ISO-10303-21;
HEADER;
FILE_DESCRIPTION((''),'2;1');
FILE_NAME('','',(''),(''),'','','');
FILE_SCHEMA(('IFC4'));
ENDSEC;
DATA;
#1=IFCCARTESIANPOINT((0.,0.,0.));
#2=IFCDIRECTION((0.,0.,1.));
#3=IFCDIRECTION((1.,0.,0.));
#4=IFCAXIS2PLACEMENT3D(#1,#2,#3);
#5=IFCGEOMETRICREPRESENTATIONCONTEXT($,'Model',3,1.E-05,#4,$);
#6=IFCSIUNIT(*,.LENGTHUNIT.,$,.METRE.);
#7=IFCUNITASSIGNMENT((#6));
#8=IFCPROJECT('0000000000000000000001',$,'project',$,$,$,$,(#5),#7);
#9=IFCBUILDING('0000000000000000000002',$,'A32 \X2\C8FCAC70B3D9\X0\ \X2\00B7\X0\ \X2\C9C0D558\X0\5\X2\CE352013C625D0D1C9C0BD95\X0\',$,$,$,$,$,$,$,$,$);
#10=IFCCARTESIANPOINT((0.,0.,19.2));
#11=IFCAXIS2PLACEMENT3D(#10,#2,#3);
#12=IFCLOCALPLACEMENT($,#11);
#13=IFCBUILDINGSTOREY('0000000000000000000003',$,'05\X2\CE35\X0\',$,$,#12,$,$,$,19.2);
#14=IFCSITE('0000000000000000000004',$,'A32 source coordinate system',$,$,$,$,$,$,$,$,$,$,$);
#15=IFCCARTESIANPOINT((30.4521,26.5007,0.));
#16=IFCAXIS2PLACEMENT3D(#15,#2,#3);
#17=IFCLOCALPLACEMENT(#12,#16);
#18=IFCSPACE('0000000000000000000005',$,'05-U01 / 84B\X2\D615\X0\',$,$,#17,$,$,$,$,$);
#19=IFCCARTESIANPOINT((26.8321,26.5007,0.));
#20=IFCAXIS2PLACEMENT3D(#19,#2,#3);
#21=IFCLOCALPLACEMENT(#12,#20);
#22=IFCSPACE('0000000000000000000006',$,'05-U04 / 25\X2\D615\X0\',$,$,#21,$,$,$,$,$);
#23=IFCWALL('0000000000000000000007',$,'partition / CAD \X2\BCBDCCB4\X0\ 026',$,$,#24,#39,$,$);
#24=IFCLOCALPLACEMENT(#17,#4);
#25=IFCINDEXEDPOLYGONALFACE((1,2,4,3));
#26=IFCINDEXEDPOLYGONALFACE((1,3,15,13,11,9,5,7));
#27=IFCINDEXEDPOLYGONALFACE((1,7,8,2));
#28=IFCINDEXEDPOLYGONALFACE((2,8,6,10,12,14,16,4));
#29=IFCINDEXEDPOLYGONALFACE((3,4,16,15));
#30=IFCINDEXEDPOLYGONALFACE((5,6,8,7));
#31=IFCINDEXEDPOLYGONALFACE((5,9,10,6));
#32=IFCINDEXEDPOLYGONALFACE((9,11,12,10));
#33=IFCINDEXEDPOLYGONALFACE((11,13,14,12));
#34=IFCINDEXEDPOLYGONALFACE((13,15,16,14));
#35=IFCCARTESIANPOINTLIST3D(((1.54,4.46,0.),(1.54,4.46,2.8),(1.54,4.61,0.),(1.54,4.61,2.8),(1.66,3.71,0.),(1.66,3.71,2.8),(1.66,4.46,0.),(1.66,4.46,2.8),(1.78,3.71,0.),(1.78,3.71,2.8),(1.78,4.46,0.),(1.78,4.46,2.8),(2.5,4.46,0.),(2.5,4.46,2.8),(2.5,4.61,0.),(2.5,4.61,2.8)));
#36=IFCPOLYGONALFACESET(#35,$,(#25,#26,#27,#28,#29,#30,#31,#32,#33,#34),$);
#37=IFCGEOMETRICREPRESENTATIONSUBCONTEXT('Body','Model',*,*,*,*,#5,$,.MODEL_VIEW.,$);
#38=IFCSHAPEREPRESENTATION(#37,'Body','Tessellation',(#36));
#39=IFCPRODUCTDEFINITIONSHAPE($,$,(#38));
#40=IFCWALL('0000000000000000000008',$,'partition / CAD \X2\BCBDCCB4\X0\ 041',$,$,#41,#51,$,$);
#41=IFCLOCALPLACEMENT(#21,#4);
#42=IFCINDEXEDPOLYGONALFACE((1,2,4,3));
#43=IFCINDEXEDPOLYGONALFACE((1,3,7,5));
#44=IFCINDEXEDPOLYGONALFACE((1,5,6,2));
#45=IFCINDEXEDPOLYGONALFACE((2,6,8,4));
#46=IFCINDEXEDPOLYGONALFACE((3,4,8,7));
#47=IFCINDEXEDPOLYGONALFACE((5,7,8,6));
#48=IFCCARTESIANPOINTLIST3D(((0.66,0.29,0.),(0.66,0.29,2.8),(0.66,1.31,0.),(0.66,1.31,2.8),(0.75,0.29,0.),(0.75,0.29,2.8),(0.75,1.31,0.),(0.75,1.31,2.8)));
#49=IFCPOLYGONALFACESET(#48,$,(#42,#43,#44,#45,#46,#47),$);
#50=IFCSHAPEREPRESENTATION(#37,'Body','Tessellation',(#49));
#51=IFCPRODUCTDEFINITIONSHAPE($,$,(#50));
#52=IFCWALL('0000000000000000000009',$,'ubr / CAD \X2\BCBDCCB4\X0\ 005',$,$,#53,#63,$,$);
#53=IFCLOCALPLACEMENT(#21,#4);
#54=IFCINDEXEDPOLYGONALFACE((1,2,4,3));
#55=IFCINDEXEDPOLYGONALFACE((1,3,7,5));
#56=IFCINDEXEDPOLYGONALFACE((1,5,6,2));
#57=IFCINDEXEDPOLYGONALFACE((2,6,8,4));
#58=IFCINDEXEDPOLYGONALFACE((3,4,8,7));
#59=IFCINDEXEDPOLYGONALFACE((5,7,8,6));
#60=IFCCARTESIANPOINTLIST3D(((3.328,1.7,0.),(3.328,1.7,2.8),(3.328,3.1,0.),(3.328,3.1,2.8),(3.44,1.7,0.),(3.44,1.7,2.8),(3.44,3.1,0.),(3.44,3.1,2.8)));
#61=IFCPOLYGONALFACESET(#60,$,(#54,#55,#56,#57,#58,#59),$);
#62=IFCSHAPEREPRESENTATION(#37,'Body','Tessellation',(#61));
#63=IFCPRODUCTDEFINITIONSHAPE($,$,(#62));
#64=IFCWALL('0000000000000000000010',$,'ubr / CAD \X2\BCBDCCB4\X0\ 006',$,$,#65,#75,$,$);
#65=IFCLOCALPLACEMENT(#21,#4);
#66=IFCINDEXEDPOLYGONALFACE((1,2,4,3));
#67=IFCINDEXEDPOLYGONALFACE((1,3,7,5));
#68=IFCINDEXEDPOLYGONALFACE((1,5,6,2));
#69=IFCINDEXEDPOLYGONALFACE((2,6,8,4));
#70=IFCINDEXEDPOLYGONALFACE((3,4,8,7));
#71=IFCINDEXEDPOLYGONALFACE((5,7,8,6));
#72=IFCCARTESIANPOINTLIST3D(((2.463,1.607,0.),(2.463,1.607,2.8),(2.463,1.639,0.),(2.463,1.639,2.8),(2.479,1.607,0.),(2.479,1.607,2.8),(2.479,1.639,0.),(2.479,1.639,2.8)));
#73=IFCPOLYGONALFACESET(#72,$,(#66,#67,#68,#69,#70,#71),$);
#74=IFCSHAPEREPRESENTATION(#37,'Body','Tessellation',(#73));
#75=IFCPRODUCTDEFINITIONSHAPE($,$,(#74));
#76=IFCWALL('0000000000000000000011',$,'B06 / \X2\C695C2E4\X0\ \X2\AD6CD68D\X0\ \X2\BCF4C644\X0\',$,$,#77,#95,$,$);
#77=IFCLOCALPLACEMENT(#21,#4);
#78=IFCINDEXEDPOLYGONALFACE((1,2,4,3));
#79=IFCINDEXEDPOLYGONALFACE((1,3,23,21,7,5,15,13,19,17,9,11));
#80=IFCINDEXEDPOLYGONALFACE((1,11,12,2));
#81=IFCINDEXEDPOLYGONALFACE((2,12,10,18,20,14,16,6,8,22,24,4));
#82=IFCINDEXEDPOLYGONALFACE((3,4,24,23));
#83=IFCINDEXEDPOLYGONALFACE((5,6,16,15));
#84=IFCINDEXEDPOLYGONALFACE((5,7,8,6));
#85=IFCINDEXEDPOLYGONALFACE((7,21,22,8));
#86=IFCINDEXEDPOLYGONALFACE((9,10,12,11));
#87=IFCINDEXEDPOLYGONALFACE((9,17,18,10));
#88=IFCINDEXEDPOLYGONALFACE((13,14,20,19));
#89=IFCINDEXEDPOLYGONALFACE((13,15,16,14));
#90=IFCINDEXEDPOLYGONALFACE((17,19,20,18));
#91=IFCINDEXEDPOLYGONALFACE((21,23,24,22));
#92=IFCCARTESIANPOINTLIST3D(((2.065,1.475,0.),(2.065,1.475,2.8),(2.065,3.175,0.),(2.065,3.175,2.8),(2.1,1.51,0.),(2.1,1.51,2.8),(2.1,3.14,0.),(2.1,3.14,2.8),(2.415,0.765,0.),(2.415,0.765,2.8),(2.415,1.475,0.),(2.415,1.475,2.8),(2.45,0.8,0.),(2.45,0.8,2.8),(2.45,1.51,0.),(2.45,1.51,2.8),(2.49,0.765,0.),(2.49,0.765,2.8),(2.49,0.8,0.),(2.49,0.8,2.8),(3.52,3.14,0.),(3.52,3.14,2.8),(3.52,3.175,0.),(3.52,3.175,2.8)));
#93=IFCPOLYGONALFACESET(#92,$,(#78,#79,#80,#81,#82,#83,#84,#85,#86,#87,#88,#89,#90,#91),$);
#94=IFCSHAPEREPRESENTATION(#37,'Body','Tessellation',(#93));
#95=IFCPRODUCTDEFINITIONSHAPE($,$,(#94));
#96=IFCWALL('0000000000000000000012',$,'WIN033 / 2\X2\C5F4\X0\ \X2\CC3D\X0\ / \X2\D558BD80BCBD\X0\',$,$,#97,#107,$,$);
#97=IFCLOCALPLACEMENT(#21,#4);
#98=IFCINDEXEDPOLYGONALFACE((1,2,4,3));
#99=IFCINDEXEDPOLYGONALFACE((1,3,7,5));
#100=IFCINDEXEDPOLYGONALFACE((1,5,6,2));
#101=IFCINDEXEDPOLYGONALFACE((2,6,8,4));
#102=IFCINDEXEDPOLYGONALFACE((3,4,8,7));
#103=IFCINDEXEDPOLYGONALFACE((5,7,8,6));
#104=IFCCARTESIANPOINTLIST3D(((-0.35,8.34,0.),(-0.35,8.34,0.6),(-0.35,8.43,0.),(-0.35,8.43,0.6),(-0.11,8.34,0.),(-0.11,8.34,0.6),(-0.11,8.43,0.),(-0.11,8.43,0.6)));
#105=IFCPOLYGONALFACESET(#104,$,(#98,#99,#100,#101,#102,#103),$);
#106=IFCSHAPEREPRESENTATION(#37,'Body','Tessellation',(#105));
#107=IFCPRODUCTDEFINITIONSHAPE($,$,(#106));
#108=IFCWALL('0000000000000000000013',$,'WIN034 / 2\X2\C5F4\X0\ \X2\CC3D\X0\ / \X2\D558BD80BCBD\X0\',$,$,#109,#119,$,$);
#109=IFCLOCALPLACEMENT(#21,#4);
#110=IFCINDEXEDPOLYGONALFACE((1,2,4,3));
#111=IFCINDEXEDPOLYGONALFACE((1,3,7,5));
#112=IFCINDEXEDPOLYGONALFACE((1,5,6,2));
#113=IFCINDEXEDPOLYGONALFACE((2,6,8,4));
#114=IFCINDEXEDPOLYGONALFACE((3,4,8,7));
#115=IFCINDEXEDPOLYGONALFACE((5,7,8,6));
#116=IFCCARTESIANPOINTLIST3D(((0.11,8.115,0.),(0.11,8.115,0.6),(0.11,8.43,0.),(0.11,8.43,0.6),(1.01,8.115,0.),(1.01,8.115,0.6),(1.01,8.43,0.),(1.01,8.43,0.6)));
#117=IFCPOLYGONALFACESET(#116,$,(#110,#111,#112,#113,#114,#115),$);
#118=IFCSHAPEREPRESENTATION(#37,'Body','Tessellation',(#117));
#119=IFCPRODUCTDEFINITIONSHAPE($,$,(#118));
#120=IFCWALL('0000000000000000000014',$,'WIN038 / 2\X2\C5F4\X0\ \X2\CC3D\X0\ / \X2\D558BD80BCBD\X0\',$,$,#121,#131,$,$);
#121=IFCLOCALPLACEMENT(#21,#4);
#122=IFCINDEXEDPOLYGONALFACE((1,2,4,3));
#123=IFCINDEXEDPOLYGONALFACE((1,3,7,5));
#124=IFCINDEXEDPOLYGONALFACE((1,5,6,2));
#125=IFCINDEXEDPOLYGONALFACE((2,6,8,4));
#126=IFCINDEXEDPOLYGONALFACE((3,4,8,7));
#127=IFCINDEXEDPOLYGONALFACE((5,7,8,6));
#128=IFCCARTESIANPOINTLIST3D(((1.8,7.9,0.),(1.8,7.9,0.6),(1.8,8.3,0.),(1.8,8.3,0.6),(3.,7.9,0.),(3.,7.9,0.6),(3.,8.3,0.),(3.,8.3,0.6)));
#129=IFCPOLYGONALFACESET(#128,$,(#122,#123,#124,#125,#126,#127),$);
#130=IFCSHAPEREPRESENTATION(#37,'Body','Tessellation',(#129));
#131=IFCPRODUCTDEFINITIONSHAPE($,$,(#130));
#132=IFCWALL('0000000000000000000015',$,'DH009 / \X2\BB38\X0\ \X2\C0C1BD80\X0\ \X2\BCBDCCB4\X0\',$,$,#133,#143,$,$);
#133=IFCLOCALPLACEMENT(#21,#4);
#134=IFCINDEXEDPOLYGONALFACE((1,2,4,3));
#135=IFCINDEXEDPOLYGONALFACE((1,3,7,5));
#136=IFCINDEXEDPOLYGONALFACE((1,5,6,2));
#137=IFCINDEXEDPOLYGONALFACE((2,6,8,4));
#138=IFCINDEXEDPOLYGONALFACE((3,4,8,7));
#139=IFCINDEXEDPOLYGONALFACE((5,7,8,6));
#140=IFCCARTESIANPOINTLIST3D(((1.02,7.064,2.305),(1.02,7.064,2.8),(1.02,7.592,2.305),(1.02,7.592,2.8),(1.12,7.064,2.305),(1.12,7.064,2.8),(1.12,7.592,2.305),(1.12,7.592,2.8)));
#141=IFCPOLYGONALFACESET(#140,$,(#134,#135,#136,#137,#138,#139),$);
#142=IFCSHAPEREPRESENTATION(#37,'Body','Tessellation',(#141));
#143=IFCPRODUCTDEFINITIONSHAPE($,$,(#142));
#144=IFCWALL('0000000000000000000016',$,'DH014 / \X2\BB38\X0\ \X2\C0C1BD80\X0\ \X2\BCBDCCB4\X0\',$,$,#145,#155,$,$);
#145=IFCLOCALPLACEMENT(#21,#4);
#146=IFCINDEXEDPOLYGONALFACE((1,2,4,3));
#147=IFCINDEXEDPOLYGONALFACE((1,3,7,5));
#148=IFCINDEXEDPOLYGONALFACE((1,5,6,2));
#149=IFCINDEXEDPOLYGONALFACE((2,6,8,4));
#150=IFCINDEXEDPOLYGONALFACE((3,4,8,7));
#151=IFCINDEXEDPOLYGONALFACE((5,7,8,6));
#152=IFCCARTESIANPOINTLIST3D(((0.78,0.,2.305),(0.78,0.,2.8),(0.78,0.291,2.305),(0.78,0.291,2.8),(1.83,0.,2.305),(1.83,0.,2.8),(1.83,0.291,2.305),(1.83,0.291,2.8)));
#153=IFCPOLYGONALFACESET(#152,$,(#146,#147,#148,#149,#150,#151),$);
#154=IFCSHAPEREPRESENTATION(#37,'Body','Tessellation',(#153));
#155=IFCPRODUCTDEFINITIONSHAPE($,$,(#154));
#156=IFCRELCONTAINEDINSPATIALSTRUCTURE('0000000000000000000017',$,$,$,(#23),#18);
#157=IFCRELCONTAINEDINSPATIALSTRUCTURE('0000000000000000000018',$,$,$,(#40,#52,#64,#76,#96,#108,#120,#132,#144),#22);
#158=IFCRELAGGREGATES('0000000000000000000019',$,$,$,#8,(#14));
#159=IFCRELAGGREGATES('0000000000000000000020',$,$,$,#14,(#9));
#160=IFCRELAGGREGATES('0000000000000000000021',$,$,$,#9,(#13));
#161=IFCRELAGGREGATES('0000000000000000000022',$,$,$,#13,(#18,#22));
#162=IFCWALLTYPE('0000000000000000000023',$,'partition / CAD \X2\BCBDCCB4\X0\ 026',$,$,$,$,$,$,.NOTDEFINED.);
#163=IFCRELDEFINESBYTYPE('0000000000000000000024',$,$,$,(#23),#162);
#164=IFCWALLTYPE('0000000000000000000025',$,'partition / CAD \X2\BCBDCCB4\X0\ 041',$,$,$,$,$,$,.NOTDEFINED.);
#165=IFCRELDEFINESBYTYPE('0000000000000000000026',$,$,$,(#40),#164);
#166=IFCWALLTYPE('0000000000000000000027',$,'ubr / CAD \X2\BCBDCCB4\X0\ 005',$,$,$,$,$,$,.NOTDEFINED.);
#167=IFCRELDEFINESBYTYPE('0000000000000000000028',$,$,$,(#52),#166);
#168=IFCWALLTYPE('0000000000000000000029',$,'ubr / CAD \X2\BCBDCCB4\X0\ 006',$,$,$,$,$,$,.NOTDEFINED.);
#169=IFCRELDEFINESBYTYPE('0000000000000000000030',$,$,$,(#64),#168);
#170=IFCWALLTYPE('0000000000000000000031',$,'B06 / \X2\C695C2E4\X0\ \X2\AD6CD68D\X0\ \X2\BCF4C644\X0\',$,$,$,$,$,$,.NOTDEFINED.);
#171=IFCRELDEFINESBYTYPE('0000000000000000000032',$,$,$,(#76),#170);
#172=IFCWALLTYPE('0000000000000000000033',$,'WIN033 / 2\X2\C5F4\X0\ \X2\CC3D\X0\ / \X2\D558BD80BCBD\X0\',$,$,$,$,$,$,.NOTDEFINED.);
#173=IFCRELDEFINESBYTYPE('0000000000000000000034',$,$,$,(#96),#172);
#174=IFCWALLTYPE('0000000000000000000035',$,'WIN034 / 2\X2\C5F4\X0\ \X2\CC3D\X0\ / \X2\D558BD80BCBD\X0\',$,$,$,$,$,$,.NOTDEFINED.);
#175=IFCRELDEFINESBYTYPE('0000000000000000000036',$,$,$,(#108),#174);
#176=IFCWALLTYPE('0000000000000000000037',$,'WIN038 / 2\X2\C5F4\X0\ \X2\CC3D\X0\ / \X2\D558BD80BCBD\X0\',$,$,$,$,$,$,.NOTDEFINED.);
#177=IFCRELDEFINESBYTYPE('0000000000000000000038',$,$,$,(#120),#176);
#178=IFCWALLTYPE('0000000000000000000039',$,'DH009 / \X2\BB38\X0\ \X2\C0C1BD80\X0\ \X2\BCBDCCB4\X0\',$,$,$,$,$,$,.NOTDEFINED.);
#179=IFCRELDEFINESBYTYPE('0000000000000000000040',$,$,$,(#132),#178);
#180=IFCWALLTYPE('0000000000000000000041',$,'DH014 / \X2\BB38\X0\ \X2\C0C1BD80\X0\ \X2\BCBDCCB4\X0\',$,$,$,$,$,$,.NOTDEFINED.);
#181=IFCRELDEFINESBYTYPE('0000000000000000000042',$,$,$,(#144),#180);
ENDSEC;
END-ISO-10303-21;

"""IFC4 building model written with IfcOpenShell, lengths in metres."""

from ifc_helpers import new_model, si_unit, frame, origin, origin_with_axes, place, context, subcontext, project, spatial, polyline, outline, extrude, source, transform, mapped, type_object, type_shapes, element, save


model = new_model("IFC4")

# Units and contexts
model_context = context("Model", 3, precision=1e-05, world=origin_with_axes())
body_context = subcontext(model_context, "Body", "Model", "MODEL_VIEW")
ifc_project = project(units=[si_unit("LENGTHUNIT", "METRE")], contexts=[model_context])

# Site, building, storey, space
site = spatial("IfcSite", under=ifc_project, Name="A32 source coordinate system")
building = spatial("IfcBuilding", under=site, Name="A32 주거동 · 지하5층–옥탑지붕")
storey_placement = place(None, frame((0.0, 0.0, 19.2), z_axis=(0.0, 0.0, 1.0), x_axis=(1.0, 0.0, 0.0)))
storey = spatial("IfcBuildingStorey", under=building, at=storey_placement, Name="05층", Elevation=19.2)
space_1_placement = place(storey_placement, frame((30.4521, 26.5007, 0.0), z_axis=(0.0, 0.0, 1.0), x_axis=(1.0, 0.0, 0.0)))
space_1 = spatial("IfcSpace", under=storey, at=space_1_placement, Name="05-U01 / 84B형")

# Wall
wall_type_1 = type_object("IfcWallType", Name="partition / CAD 벽체 026", PredefinedType="NOTDEFINED")
shared_shape_1 = source(origin(), body_context, "Body", "SweptSolid", [
    extrude(outline(polyline([(1.54, 4.46), (1.54, 4.61), (2.5, 4.61), (2.5, 4.46), (1.78, 4.46), (1.78, 3.71), (1.66, 3.71), (1.66, 4.46), (1.54, 4.46)])), origin(), (0.0, 0.0, 1.0), 2.8),
])
type_shapes(wall_type_1, [shared_shape_1])
wall_1_placement = place(space_1_placement, origin_with_axes())
element("IfcWall", 1, at=wall_1_placement, inside=space_1, type_object=wall_type_1, Name="partition / CAD 벽체 026", context=body_context, shape_type="MappedRepresentation", body=[
    mapped(shared_shape_1, transform((0.0, 0.0, 0.0), scale=1.0)),
])

# Shared definitions
space_2_placement = place(storey_placement, frame((26.8321, 26.5007, 0.0), z_axis=(0.0, 0.0, 1.0), x_axis=(1.0, 0.0, 0.0)))
space_2 = spatial("IfcSpace", under=storey, at=space_2_placement, Name="05-U04 / 25형")

# Walls
wall_type_2 = type_object("IfcWallType", Name="partition / CAD 벽체 041", PredefinedType="NOTDEFINED")
shared_shape_2 = source(origin(), body_context, "Body", "SweptSolid", [
    extrude(outline(polyline([(0.75, 1.31), (0.75, 0.29), (0.66, 0.29), (0.66, 1.31), (0.75, 1.31)])), origin(), (0.0, 0.0, 1.0), 2.8),
])
type_shapes(wall_type_2, [shared_shape_2])
wall_2_placement = place(space_2_placement, origin_with_axes())
element("IfcWall", 2, at=wall_2_placement, inside=space_2, type_object=wall_type_2, Name="partition / CAD 벽체 041", context=body_context, shape_type="MappedRepresentation", body=[
    mapped(shared_shape_2, transform((0.0, 0.0, 0.0), scale=1.0)),
])
wall_type_3 = type_object("IfcWallType", Name="ubr / CAD 벽체 005", PredefinedType="NOTDEFINED")
shared_shape_3 = source(origin(), body_context, "Body", "SweptSolid", [
    extrude(outline(polyline([(3.44, 3.1), (3.44, 1.7), (3.328, 1.7), (3.328, 3.1), (3.44, 3.1)])), origin(), (0.0, 0.0, 1.0), 2.8),
])
type_shapes(wall_type_3, [shared_shape_3])
wall_3_placement = place(space_2_placement, origin_with_axes())
element("IfcWall", 3, at=wall_3_placement, inside=space_2, type_object=wall_type_3, Name="ubr / CAD 벽체 005", context=body_context, shape_type="MappedRepresentation", body=[
    mapped(shared_shape_3, transform((0.0, 0.0, 0.0), scale=1.0)),
])
wall_type_4 = type_object("IfcWallType", Name="ubr / CAD 벽체 006", PredefinedType="NOTDEFINED")
shared_shape_4 = source(origin(), body_context, "Body", "SweptSolid", [
    extrude(outline(polyline([(2.463, 1.639), (2.479, 1.639), (2.479, 1.607), (2.463, 1.607), (2.463, 1.639)])), origin(), (0.0, 0.0, 1.0), 2.8),
])
type_shapes(wall_type_4, [shared_shape_4])
wall_4_placement = place(space_2_placement, origin_with_axes())
element("IfcWall", 4, at=wall_4_placement, inside=space_2, type_object=wall_type_4, Name="ubr / CAD 벽체 006", context=body_context, shape_type="MappedRepresentation", body=[
    mapped(shared_shape_4, transform((0.0, 0.0, 0.0), scale=1.0)),
])
wall_type_5 = type_object("IfcWallType", Name="B06 / 욕실 구획 보완", PredefinedType="NOTDEFINED")
shared_shape_5 = source(origin(), body_context, "Body", "SweptSolid", [
    extrude(outline(polyline([(3.52, 3.14), (2.1, 3.14), (2.1, 1.51), (2.45, 1.51), (2.45, 0.8), (2.49, 0.8), (2.49, 0.765), (2.415, 0.765), (2.415, 1.475), (2.065, 1.475), (2.065, 3.175), (3.52, 3.175), (3.52, 3.14)])), origin(), (0.0, 0.0, 1.0), 2.8),
])
type_shapes(wall_type_5, [shared_shape_5])
wall_5_placement = place(space_2_placement, origin_with_axes())
element("IfcWall", 5, at=wall_5_placement, inside=space_2, type_object=wall_type_5, Name="B06 / 욕실 구획 보완", context=body_context, shape_type="MappedRepresentation", body=[
    mapped(shared_shape_5, transform((0.0, 0.0, 0.0), scale=1.0)),
])
wall_type_6 = type_object("IfcWallType", Name="WIN033 / 2열 창 / 하부벽", PredefinedType="NOTDEFINED")
shared_shape_6 = source(origin(), body_context, "Body", "SweptSolid", [
    extrude(outline(polyline([(-0.11, 8.43), (-0.11, 8.34), (-0.35, 8.34), (-0.35, 8.43), (-0.11, 8.43)])), origin(), (0.0, 0.0, 1.0), 0.6),
])
type_shapes(wall_type_6, [shared_shape_6])
wall_6_placement = place(space_2_placement, origin_with_axes())
element("IfcWall", 6, at=wall_6_placement, inside=space_2, type_object=wall_type_6, Name="WIN033 / 2열 창 / 하부벽", context=body_context, shape_type="MappedRepresentation", body=[
    mapped(shared_shape_6, transform((0.0, 0.0, 0.0), scale=1.0)),
])
wall_type_7 = type_object("IfcWallType", Name="WIN034 / 2열 창 / 하부벽", PredefinedType="NOTDEFINED")
shared_shape_7 = source(origin(), body_context, "Body", "SweptSolid", [
    extrude(outline(polyline([(0.11, 8.115), (0.11, 8.43), (1.01, 8.43), (1.01, 8.115), (0.11, 8.115)])), origin(), (0.0, 0.0, 1.0), 0.6),
])
type_shapes(wall_type_7, [shared_shape_7])
wall_7_placement = place(space_2_placement, origin_with_axes())
element("IfcWall", 7, at=wall_7_placement, inside=space_2, type_object=wall_type_7, Name="WIN034 / 2열 창 / 하부벽", context=body_context, shape_type="MappedRepresentation", body=[
    mapped(shared_shape_7, transform((0.0, 0.0, 0.0), scale=1.0)),
])
wall_type_8 = type_object("IfcWallType", Name="WIN038 / 2열 창 / 하부벽", PredefinedType="NOTDEFINED")
shared_shape_8 = source(origin(), body_context, "Body", "SweptSolid", [
    extrude(outline(polyline([(1.8, 7.9), (1.8, 8.3), (3.0, 8.3), (3.0, 7.9), (1.8, 7.9)])), origin(), (0.0, 0.0, 1.0), 0.6),
])
type_shapes(wall_type_8, [shared_shape_8])
wall_8_placement = place(space_2_placement, origin_with_axes())
element("IfcWall", 8, at=wall_8_placement, inside=space_2, type_object=wall_type_8, Name="WIN038 / 2열 창 / 하부벽", context=body_context, shape_type="MappedRepresentation", body=[
    mapped(shared_shape_8, transform((0.0, 0.0, 0.0), scale=1.0)),
])
wall_type_9 = type_object("IfcWallType", Name="DH009 / 문 상부 벽체", PredefinedType="NOTDEFINED")
shared_shape_9 = source(origin(), body_context, "Body", "SweptSolid", [
    extrude(outline(polyline([(1.02, 7.064), (1.02, 7.592), (1.12, 7.592), (1.12, 7.064), (1.02, 7.064)])), frame((0.0, 0.0, 2.305)), (0.0, 0.0, 1.0), 0.495),
])
type_shapes(wall_type_9, [shared_shape_9])
wall_9_placement = place(space_2_placement, origin_with_axes())
element("IfcWall", 9, at=wall_9_placement, inside=space_2, type_object=wall_type_9, Name="DH009 / 문 상부 벽체", context=body_context, shape_type="MappedRepresentation", body=[
    mapped(shared_shape_9, transform((0.0, 0.0, 0.0), scale=1.0)),
])
wall_type_10 = type_object("IfcWallType", Name="DH014 / 문 상부 벽체", PredefinedType="NOTDEFINED")
shared_shape_10 = source(origin(), body_context, "Body", "SweptSolid", [
    extrude(outline(polyline([(0.78, 0.291), (1.83, 0.291), (1.83, 0.0), (0.78, 0.0), (0.78, 0.291)])), frame((0.0, 0.0, 2.305)), (0.0, 0.0, 1.0), 0.495),
])
type_shapes(wall_type_10, [shared_shape_10])
wall_10_placement = place(space_2_placement, origin_with_axes())
element("IfcWall", 10, at=wall_10_placement, inside=space_2, type_object=wall_type_10, Name="DH014 / 문 상부 벽체", context=body_context, shape_type="MappedRepresentation", body=[
    mapped(shared_shape_10, transform((0.0, 0.0, 0.0), scale=1.0)),
])

save(model, "model.ifc")
